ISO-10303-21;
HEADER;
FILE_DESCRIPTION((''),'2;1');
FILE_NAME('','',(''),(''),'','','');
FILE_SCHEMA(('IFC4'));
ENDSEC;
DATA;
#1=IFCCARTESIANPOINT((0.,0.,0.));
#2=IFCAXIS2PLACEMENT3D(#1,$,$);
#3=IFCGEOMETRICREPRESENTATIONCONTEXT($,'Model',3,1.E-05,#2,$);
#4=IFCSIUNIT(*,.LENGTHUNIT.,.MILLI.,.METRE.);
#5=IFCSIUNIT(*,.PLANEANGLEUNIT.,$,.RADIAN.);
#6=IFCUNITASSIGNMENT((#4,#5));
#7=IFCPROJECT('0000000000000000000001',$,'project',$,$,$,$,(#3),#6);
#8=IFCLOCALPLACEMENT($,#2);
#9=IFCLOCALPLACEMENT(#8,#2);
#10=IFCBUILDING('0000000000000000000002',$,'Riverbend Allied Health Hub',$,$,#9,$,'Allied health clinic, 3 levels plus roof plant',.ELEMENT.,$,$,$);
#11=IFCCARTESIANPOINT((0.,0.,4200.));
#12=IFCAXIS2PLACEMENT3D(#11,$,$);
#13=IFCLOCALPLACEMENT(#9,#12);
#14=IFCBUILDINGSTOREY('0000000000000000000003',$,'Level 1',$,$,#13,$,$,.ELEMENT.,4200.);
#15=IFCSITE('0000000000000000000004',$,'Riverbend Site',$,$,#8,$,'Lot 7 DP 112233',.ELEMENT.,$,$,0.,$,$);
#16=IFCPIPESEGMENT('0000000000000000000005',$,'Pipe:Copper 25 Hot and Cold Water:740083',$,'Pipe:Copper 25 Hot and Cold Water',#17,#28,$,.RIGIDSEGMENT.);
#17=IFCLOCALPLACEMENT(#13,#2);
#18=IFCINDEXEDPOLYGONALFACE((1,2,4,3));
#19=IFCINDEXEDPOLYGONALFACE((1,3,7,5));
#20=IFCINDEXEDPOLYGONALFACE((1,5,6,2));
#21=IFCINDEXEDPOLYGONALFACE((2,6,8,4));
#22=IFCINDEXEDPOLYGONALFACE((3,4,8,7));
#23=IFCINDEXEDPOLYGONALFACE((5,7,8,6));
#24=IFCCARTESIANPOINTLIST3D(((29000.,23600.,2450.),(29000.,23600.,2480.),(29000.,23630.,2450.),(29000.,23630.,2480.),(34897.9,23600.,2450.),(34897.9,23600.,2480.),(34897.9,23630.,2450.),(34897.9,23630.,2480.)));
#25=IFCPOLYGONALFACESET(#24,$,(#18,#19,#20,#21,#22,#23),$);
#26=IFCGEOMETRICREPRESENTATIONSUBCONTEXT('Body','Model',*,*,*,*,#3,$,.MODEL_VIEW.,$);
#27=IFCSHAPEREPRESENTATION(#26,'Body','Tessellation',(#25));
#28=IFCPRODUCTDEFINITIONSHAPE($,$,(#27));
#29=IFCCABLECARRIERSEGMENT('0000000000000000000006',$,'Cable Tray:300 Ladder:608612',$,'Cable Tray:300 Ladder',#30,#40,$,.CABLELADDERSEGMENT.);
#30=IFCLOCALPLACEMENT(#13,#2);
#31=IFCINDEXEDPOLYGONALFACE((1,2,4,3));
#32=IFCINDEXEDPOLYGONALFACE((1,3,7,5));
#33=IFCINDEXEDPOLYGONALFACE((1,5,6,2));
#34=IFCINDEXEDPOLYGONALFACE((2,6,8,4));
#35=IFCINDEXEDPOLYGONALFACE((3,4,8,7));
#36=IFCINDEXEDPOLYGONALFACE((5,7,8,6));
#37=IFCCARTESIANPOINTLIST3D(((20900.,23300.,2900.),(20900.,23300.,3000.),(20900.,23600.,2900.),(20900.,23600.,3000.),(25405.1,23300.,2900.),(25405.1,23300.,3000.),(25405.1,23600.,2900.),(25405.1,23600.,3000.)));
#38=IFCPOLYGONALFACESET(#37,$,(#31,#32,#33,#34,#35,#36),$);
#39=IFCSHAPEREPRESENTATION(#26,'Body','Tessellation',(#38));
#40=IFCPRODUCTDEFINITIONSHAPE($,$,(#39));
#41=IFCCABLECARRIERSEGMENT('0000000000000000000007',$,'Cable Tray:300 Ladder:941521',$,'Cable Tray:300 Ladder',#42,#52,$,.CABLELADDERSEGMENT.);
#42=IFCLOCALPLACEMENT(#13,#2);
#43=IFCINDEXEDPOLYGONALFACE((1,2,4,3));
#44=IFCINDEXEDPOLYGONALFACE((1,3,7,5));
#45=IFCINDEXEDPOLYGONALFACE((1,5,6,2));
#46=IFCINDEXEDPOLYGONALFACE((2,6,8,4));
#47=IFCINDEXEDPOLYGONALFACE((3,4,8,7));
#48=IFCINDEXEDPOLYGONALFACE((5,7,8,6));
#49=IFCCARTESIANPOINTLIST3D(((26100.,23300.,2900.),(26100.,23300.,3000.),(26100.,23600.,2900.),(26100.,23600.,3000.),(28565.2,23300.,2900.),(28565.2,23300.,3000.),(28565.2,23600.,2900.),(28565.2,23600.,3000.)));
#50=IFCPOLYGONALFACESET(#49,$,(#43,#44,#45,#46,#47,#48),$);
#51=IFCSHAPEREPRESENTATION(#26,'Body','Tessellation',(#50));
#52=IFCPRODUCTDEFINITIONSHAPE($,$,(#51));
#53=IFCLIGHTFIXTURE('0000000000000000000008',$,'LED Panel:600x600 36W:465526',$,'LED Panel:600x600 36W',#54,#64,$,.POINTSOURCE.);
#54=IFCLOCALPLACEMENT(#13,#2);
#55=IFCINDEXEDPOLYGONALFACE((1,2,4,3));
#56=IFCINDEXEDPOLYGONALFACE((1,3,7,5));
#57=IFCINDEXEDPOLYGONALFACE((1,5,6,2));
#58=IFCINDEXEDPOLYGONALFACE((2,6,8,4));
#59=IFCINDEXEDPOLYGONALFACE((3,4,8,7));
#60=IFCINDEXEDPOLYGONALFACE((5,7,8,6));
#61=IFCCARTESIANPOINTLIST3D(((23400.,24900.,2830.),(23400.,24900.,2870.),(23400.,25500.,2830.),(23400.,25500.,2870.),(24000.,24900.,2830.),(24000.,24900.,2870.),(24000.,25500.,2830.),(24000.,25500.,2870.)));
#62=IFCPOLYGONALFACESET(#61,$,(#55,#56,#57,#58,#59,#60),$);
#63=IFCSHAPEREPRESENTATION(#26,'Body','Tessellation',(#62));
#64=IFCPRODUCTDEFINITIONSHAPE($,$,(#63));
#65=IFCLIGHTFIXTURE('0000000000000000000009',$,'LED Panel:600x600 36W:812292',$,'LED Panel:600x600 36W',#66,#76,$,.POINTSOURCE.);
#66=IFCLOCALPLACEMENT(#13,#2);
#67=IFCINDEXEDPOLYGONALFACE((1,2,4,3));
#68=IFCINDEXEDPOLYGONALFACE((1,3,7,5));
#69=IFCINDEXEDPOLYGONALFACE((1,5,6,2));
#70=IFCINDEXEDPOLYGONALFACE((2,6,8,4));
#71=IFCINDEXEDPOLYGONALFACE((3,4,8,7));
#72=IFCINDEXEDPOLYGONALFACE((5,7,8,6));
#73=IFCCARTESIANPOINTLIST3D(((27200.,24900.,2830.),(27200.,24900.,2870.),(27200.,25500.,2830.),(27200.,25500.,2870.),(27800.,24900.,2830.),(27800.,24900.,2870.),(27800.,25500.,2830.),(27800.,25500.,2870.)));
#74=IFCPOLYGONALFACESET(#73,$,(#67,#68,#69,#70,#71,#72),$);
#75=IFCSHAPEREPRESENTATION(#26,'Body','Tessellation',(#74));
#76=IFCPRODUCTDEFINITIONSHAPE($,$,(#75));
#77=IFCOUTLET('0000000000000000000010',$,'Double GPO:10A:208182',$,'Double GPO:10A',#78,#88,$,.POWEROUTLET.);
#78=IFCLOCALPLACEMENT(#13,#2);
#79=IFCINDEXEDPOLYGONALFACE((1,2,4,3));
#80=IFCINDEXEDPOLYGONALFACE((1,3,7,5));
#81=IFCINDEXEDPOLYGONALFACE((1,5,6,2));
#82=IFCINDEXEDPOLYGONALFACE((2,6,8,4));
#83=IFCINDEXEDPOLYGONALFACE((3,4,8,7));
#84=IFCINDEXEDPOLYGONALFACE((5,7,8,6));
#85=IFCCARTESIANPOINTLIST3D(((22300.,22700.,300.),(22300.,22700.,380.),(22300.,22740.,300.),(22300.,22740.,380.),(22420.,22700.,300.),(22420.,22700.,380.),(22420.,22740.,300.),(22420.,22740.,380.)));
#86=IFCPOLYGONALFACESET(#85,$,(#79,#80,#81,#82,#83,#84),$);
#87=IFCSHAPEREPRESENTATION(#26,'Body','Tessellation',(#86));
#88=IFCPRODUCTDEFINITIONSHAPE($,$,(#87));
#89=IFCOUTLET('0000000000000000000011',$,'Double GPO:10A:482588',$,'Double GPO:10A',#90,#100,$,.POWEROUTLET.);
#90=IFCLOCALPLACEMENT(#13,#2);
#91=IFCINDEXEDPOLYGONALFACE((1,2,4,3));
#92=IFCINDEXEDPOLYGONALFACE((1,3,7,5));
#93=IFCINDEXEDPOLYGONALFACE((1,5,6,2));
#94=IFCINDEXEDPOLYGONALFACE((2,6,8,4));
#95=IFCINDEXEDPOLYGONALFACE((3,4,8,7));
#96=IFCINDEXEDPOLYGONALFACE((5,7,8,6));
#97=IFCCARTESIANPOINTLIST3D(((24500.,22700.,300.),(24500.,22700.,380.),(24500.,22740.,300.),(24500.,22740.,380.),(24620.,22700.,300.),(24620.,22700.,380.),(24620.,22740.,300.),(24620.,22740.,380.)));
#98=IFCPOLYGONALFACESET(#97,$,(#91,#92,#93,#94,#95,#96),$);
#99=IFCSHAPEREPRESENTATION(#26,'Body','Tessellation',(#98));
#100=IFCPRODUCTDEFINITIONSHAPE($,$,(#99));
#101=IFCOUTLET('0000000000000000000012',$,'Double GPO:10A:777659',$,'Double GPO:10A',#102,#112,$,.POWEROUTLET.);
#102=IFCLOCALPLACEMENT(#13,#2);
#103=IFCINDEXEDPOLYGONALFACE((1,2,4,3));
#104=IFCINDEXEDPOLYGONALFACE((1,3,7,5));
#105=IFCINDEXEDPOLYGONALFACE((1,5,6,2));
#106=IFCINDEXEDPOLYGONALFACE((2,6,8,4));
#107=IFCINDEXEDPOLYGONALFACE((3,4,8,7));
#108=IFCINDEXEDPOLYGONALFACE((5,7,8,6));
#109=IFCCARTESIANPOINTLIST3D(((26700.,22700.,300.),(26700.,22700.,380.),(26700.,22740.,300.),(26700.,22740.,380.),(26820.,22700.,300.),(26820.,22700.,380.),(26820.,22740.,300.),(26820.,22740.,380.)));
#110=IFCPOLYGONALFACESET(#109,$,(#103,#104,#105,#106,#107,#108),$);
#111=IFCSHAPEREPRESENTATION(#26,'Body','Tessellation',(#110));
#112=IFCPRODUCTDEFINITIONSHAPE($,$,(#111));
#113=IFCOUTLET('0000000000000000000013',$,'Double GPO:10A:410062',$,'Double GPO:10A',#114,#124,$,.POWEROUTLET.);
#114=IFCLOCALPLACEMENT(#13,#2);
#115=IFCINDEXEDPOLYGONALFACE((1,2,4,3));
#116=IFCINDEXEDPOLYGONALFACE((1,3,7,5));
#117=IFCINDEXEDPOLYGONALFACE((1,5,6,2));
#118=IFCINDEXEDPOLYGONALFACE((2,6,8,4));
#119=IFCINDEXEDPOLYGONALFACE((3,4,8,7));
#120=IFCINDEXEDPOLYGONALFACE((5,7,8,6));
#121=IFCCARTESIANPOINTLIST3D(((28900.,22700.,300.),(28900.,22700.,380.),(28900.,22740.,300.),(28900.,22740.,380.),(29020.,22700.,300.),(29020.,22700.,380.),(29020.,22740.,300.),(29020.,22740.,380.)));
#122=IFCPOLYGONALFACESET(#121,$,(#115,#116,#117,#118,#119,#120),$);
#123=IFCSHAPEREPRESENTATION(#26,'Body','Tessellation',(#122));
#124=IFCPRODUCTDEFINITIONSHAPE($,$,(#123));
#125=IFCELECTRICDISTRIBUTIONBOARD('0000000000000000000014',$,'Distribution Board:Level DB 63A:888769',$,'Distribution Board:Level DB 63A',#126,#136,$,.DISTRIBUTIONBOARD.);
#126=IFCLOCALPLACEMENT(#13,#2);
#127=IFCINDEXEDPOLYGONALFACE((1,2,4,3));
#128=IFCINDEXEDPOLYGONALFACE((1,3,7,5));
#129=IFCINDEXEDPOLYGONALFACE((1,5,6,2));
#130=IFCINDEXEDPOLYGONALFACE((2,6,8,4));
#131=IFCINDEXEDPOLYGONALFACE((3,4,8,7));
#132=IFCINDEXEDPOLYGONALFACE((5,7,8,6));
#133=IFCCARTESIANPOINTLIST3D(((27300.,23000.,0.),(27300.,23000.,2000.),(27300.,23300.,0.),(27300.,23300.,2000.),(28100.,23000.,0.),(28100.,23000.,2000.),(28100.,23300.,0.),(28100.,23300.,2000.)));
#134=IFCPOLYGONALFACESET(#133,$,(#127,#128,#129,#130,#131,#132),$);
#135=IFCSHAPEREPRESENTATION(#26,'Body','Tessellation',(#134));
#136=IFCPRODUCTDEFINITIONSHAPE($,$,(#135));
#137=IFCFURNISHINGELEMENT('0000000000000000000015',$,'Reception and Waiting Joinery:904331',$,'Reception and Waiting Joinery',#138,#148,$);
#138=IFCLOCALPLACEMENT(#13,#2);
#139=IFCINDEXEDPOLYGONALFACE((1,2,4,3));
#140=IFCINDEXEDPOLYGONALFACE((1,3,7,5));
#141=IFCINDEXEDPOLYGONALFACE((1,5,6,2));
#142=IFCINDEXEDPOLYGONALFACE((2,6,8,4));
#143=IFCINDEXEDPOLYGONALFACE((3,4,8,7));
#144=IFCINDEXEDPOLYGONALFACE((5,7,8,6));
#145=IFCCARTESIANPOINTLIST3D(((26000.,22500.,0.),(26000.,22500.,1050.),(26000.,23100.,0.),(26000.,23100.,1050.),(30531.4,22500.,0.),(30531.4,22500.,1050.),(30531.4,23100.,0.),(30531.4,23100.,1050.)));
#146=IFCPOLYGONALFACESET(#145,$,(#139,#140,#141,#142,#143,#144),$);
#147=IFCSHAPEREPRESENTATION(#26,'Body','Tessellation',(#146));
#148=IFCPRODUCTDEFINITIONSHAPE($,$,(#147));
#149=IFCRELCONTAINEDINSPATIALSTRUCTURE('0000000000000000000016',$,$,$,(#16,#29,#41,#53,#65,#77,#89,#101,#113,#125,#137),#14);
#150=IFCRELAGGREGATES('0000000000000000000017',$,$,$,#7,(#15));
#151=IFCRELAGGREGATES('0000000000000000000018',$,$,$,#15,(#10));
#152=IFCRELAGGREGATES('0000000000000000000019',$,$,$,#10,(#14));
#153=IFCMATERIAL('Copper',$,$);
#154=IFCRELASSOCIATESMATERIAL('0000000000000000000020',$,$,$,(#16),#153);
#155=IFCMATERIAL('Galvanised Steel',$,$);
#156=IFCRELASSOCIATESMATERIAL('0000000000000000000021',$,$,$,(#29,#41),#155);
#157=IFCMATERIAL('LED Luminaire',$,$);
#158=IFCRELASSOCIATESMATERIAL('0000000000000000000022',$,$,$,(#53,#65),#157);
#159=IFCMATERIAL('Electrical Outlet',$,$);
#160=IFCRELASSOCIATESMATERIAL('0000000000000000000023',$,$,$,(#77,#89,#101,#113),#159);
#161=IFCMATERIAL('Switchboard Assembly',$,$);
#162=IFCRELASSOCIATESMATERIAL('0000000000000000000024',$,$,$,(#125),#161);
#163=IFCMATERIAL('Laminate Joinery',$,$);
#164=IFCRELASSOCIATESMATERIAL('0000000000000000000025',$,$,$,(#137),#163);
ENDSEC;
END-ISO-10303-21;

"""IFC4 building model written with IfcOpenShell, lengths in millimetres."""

from ifc_helpers import new_model, si_unit, frame, frame_2d, origin, place, context, subcontext, project, spatial, rectangle, extrude, material, element, save


model = new_model("IFC4")

# Units and contexts
model_context = context("Model", 3, precision=1e-05, world=origin())
body_context = subcontext(model_context, "Body", "Model", "MODEL_VIEW")
ifc_project = project(units=[si_unit("LENGTHUNIT", "METRE", prefix="MILLI"), si_unit("PLANEANGLEUNIT", "RADIAN")], contexts=[model_context])

# Site, building, storey
site_placement = place(None, origin())
site = spatial("IfcSite", under=ifc_project, at=site_placement, Name="Riverbend Site", LongName="Lot 7 DP 112233", CompositionType="ELEMENT", RefElevation=0.0)
building_placement = place(site_placement, origin())
building = spatial("IfcBuilding", under=site, at=building_placement, Name="Riverbend Allied Health Hub", LongName="Allied health clinic, 3 levels plus roof plant", CompositionType="ELEMENT")
storey_placement = place(building_placement, frame((0.0, 0.0, 4200.0)))
storey = spatial("IfcBuildingStorey", under=building, at=storey_placement, Name="Level 1", CompositionType="ELEMENT", Elevation=4200.0)

# Shared definitions
ifc_material_1 = material(Name="Galvanised Steel")

# Pipe segment
ifc_material_2 = material(Name="Copper")
pipe_segment_1_placement = place(storey_placement, frame((29000.0, 23600.0, 2450.0)))
element("IfcPipeSegment", 1, at=pipe_segment_1_placement, inside=storey, material=ifc_material_2, Name="Pipe:Copper 25 Hot and Cold Water:740083", ObjectType="Pipe:Copper 25 Hot and Cold Water", PredefinedType="RIGIDSEGMENT", context=body_context, shape_type="SweptSolid", body=[
    extrude(rectangle(XDim=5897.9, YDim=30.0, at=frame_2d((2948.9, 15.0))), origin(), (0.0, 0.0, 1.0), 30.0),
])

# Cable carrier segments
cable_carrier_segment_1_placement = place(storey_placement, frame((20900.0, 23300.0, 2900.0)))
element("IfcCableCarrierSegment", 2, at=cable_carrier_segment_1_placement, inside=storey, material=ifc_material_1, Name="Cable Tray:300 Ladder:608612", ObjectType="Cable Tray:300 Ladder", PredefinedType="CABLELADDERSEGMENT", context=body_context, shape_type="SweptSolid", body=[
    extrude(rectangle(XDim=4505.1, YDim=300.0, at=frame_2d((2252.5, 150.0))), origin(), (0.0, 0.0, 1.0), 100.0),
])
cable_carrier_segment_2_placement = place(storey_placement, frame((26100.0, 23300.0, 2900.0)))
element("IfcCableCarrierSegment", 3, at=cable_carrier_segment_2_placement, inside=storey, material=ifc_material_1, Name="Cable Tray:300 Ladder:941521", ObjectType="Cable Tray:300 Ladder", PredefinedType="CABLELADDERSEGMENT", context=body_context, shape_type="SweptSolid", body=[
    extrude(rectangle(XDim=2465.2, YDim=300.0, at=frame_2d((1232.6, 150.0))), origin(), (0.0, 0.0, 1.0), 100.0),
])

# Light fixtures
ifc_material_3 = material(Name="LED Luminaire")
for number, where, name in (
    (4, (23400.0, 24900.0, 2830.0), "LED Panel:600x600 36W:465526"),
    (5, (27200.0, 24900.0, 2830.0), "LED Panel:600x600 36W:812292"),
):
    element("IfcLightFixture", number, at=place(storey_placement, frame(where)), inside=storey, material=ifc_material_3, Name=name, ObjectType="LED Panel:600x600 36W", PredefinedType="POINTSOURCE", context=body_context, shape_type="SweptSolid", body=[
        extrude(rectangle(XDim=600.0, YDim=600.0, at=frame_2d((300.0, 300.0))), origin(), (0.0, 0.0, 1.0), 40.0),
    ])

# Outlets
ifc_material_4 = material(Name="Electrical Outlet")
for number, where, name in (
    (6, (22300.0, 22700.0, 300.0), "Double GPO:10A:208182"),
    (7, (24500.0, 22700.0, 300.0), "Double GPO:10A:482588"),
    (8, (26700.0, 22700.0, 300.0), "Double GPO:10A:777659"),
    (9, (28900.0, 22700.0, 300.0), "Double GPO:10A:410062"),
):
    element("IfcOutlet", number, at=place(storey_placement, frame(where)), inside=storey, material=ifc_material_4, Name=name, ObjectType="Double GPO:10A", PredefinedType="POWEROUTLET", context=body_context, shape_type="SweptSolid", body=[
        extrude(rectangle(XDim=120.0, YDim=40.0, at=frame_2d((60.0, 20.0))), origin(), (0.0, 0.0, 1.0), 80.0),
    ])

# Electric distribution board
ifc_material_5 = material(Name="Switchboard Assembly")
electric_distribution_board_placement = place(storey_placement, frame((27300.0, 23000.0, 0.0)))
element("IfcElectricDistributionBoard", 10, at=electric_distribution_board_placement, inside=storey, material=ifc_material_5, Name="Distribution Board:Level DB 63A:888769", ObjectType="Distribution Board:Level DB 63A", PredefinedType="DISTRIBUTIONBOARD", context=body_context, shape_type="SweptSolid", body=[
    extrude(rectangle(XDim=800.0, YDim=300.0, at=frame_2d((400.0, 150.0))), origin(), (0.0, 0.0, 1.0), 2000.0),
])

# Furnishing element
ifc_material_6 = material(Name="Laminate Joinery")
furnishing_placement = place(storey_placement, frame((26000.0, 22500.0, 0.0)))
element("IfcFurnishingElement", 11, at=furnishing_placement, inside=storey, material=ifc_material_6, Name="Reception and Waiting Joinery:904331", ObjectType="Reception and Waiting Joinery", context=body_context, shape_type="SweptSolid", body=[
    extrude(rectangle(XDim=4531.4, YDim=600.0, at=frame_2d((2265.7, 300.0))), origin(), (0.0, 0.0, 1.0), 1050.0),
])

save(model, "model.ifc")
